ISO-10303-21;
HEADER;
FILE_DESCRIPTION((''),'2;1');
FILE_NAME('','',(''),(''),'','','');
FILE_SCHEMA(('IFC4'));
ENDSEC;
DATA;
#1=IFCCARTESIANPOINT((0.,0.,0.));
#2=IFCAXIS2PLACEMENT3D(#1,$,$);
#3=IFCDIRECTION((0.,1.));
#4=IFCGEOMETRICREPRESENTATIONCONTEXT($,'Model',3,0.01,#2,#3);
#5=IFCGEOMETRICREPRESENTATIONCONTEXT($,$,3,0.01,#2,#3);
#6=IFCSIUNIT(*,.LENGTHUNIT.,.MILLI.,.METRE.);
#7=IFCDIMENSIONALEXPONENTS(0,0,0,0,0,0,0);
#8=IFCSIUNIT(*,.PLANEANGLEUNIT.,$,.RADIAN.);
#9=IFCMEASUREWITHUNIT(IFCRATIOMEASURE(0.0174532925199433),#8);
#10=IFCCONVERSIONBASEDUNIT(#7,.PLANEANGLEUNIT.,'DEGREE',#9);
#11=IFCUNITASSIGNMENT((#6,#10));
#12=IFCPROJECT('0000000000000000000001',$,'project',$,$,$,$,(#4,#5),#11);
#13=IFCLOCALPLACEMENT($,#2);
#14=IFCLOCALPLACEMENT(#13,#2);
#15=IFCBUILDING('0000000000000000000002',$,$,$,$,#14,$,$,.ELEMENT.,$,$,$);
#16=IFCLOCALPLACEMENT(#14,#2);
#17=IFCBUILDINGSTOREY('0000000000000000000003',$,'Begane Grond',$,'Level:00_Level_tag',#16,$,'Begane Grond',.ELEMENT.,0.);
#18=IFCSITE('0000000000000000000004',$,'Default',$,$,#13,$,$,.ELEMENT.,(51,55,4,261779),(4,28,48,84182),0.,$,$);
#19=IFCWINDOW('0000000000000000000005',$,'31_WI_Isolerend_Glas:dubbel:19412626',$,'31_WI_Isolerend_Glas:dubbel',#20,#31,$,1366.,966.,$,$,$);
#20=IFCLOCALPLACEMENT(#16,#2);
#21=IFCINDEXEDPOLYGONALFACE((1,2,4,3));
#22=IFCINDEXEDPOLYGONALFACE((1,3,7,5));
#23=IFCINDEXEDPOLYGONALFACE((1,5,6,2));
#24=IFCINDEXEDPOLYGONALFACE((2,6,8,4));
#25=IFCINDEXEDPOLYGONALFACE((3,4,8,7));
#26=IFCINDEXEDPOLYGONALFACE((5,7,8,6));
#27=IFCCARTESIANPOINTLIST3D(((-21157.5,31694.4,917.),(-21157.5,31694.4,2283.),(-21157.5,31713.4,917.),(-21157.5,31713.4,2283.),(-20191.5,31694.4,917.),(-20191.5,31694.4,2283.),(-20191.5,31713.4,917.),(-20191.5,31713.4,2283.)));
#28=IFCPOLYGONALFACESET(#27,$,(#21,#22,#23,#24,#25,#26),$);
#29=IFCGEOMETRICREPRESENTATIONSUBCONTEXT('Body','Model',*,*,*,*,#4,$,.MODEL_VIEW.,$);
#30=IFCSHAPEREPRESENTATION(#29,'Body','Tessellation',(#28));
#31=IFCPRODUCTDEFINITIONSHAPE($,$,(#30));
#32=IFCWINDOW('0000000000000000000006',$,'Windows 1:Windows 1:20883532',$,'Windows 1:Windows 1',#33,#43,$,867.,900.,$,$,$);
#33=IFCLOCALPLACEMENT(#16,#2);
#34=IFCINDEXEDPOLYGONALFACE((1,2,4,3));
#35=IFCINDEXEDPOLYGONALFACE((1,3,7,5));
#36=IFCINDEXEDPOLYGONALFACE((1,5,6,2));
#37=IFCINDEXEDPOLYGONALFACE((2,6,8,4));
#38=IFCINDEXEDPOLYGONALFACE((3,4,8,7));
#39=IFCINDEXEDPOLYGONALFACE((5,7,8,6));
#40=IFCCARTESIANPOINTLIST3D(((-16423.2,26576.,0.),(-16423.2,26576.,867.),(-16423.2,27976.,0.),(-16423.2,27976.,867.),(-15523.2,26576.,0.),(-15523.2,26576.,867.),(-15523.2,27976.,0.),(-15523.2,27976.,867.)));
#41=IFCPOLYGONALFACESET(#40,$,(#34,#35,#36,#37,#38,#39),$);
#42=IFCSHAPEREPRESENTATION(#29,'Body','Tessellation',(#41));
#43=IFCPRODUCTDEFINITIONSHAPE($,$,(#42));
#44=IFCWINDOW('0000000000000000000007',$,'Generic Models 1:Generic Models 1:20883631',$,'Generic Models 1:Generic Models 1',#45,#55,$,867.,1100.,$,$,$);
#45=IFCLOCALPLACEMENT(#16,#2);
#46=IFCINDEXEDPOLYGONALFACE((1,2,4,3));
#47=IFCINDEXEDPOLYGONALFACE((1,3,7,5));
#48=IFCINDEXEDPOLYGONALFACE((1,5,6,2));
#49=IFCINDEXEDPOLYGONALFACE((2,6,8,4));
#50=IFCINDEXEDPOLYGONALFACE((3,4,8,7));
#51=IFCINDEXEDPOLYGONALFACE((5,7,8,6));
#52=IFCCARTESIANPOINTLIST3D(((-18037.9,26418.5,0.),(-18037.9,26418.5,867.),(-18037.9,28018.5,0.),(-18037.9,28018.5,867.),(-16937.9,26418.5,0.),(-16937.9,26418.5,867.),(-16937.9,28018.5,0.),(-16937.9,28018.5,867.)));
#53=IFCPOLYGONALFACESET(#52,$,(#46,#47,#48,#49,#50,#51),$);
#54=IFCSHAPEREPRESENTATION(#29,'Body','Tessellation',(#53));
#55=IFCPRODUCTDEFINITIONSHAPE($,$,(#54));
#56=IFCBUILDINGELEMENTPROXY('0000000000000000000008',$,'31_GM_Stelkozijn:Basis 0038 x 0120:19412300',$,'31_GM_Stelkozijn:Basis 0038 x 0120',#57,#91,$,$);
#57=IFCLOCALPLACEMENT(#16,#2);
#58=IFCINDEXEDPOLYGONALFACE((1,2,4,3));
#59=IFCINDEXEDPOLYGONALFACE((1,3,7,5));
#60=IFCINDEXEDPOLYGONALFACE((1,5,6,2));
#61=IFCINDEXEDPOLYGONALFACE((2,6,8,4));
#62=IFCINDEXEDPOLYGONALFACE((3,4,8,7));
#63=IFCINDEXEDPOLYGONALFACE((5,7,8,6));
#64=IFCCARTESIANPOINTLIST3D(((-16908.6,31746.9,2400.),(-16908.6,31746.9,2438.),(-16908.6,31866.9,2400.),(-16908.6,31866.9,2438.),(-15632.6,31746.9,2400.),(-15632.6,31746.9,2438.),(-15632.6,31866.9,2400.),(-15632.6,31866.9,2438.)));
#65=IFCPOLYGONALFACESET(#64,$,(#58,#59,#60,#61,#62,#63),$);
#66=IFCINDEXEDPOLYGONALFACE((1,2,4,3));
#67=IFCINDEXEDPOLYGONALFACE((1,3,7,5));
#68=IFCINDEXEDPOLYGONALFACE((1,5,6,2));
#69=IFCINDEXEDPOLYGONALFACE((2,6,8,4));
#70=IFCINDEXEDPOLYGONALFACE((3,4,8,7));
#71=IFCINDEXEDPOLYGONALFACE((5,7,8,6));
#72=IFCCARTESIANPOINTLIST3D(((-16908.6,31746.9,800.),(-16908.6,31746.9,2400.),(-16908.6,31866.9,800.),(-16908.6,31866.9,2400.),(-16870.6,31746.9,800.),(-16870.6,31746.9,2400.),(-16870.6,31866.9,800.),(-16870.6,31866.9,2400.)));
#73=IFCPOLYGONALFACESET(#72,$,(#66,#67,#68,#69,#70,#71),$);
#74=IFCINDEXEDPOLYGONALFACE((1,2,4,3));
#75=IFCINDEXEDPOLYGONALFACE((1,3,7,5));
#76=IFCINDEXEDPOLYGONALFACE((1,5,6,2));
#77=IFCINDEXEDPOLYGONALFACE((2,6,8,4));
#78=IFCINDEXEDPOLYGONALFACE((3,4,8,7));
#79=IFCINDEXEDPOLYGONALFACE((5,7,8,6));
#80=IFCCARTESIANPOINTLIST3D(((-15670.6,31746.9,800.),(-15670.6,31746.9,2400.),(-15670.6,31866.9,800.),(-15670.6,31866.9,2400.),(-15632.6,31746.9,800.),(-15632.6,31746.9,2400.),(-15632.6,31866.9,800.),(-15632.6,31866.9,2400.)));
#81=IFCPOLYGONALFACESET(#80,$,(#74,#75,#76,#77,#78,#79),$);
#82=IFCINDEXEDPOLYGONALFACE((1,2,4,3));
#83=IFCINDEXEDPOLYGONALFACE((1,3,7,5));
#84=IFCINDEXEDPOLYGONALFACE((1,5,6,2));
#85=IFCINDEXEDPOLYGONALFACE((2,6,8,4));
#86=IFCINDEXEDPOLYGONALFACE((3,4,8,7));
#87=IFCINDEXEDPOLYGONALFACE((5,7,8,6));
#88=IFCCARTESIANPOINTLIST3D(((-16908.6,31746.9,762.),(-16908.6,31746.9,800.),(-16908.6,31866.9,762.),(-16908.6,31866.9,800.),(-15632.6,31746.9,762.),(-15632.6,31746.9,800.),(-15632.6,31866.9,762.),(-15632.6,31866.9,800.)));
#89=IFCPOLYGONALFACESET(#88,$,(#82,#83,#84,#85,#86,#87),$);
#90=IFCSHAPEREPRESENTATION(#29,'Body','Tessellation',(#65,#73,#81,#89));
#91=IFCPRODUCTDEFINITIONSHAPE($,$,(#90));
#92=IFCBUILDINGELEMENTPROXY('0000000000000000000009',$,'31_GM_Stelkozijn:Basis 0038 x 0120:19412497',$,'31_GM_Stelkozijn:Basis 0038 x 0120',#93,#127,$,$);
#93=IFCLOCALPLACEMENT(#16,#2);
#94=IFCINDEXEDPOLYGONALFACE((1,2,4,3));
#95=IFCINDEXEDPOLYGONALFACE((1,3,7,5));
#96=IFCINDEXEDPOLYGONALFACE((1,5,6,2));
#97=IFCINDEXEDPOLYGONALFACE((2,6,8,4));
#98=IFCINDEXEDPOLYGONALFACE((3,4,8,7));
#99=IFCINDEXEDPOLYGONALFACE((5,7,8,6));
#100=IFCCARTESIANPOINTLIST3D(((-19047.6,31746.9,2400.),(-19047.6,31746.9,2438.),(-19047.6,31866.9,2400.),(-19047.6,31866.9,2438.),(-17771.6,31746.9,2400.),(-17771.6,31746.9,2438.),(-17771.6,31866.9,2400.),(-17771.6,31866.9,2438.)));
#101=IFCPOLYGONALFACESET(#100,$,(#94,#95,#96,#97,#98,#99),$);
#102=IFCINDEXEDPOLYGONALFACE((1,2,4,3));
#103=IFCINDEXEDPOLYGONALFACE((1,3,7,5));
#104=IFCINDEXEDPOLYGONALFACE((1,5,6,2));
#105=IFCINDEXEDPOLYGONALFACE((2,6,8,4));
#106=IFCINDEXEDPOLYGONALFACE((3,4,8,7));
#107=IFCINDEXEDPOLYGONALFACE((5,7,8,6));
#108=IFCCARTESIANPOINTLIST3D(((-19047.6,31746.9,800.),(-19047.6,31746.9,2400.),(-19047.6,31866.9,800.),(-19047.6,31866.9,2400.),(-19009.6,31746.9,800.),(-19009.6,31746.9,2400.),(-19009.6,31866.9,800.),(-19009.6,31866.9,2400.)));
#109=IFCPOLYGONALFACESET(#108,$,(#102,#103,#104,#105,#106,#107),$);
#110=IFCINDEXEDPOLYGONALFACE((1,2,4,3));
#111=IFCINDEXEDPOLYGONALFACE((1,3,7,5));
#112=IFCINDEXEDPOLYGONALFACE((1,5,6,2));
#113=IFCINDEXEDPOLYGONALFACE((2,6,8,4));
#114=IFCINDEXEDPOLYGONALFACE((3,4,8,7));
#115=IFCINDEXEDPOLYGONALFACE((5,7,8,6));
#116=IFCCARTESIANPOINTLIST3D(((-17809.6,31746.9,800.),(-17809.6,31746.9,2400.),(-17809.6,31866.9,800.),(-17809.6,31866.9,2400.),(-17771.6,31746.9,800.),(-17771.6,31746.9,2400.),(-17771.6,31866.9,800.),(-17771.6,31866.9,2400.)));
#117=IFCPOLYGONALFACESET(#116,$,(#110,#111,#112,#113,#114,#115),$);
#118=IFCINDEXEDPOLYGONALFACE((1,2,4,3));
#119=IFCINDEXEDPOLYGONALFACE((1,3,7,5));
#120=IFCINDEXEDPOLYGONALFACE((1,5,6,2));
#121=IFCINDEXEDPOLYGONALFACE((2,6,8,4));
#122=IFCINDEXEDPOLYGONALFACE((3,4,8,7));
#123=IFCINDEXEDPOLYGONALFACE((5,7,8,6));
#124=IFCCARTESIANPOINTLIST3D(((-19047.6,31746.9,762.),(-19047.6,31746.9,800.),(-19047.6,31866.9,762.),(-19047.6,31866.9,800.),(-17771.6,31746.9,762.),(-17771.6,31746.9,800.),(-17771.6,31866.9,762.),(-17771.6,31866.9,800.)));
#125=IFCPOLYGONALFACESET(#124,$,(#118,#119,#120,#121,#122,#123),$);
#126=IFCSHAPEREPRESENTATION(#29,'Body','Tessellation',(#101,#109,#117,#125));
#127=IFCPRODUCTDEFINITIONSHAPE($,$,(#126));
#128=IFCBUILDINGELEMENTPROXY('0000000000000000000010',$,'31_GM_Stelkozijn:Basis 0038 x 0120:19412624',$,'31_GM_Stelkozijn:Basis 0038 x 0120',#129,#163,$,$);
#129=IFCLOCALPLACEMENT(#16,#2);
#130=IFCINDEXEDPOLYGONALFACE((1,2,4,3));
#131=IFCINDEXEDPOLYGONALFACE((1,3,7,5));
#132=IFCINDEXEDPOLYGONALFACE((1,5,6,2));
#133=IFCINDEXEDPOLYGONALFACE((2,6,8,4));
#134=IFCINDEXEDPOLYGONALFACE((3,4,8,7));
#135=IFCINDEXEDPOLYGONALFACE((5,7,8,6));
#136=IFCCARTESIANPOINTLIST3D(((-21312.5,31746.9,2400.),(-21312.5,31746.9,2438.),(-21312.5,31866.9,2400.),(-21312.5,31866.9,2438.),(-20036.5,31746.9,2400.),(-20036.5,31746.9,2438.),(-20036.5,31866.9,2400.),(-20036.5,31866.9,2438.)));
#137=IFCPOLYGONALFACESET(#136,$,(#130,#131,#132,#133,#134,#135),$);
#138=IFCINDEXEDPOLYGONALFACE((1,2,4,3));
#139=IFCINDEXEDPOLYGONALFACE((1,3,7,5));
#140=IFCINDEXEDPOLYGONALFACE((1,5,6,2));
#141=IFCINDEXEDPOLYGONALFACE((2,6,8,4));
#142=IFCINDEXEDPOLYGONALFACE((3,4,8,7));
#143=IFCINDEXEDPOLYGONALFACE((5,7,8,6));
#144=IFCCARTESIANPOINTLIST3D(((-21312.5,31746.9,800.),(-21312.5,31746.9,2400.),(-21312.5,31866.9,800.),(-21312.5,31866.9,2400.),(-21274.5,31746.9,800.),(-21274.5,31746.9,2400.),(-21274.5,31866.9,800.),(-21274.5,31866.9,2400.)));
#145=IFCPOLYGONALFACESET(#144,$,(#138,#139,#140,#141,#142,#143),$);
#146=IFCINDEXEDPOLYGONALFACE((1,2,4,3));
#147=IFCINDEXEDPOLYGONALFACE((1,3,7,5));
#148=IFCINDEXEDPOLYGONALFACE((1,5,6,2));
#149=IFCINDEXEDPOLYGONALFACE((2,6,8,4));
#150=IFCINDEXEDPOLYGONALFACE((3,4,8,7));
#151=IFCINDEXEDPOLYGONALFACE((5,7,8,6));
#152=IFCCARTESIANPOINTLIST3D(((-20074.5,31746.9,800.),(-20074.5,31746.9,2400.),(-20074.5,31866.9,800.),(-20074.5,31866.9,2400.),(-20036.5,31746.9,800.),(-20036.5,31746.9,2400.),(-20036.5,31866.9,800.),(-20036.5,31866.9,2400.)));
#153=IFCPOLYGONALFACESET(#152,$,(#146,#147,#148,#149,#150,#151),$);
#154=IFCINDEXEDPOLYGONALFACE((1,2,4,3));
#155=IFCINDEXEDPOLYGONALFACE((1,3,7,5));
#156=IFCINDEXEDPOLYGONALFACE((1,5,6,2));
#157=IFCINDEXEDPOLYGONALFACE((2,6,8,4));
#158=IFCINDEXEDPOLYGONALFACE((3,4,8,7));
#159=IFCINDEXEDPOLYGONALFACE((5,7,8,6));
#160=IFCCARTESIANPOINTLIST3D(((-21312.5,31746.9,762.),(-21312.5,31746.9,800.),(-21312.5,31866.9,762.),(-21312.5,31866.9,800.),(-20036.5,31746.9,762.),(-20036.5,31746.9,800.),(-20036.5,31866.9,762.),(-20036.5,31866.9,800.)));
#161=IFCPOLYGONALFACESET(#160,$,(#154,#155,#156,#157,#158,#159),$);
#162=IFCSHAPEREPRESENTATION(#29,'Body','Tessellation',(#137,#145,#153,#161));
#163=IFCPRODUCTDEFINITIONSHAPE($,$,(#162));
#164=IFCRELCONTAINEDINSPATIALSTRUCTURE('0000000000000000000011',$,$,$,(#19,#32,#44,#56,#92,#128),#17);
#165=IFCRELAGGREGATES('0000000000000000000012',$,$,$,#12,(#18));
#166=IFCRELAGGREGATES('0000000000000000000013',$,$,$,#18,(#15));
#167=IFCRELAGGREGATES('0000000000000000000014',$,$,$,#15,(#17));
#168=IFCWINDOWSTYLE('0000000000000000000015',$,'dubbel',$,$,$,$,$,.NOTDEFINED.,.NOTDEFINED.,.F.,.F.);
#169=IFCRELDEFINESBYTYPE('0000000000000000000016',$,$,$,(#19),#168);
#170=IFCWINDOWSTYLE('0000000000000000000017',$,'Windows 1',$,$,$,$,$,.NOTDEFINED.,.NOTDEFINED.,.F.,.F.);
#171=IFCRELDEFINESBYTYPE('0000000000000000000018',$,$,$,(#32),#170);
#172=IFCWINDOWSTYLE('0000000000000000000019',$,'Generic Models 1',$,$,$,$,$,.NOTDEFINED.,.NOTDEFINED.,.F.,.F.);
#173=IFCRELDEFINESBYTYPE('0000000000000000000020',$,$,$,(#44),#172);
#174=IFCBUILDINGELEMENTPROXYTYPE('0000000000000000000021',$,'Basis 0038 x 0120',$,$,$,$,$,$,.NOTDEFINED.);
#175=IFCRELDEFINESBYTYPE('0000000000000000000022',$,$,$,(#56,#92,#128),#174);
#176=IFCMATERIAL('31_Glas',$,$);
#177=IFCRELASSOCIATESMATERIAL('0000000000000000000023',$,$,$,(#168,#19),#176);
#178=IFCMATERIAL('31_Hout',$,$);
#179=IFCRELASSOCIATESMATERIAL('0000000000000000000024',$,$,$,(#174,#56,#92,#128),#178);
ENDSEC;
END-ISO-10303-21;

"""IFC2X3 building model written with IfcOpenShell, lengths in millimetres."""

from ifc_helpers import new_model, entity, si_unit, converted_unit, direction, frame, frame_2d, origin, origin_2d_with_axis, place, context, subcontext, project, spatial, rectangle, extrude, source, transform, mapped, material, type_object, type_shapes, element, save


model = new_model("IFC2X3")

# Units and contexts
model_context = context("Model", 3, precision=0.01, world=origin(), true_north=direction((0.0, 1.0)))
context_of_model = context(None, 3, precision=0.01, world=origin(), true_north=direction((0.0, 1.0)))
body_context = subcontext(model_context, "Body", "Model", "MODEL_VIEW")
ifc_project = project(units=[si_unit("LENGTHUNIT", "METRE", prefix="MILLI"), converted_unit("PLANEANGLEUNIT", "DEGREE", entity("IfcRatioMeasure", 0.0174532925199433), si_unit("PLANEANGLEUNIT", "RADIAN"), dimensions=[0, 0, 0, 0, 0, 0, 0])], contexts=[model_context, context_of_model])

# Site, building, storey
site_placement = place(None, origin())
site = spatial("IfcSite", under=ifc_project, at=site_placement, Name="Default", CompositionType="ELEMENT", RefLatitude=(51, 55, 4, 261779), RefLongitude=(4, 28, 48, 84182), RefElevation=0.0)
building_placement = place(site_placement, origin())
building = spatial("IfcBuilding", under=site, at=building_placement, CompositionType="ELEMENT")
storey_placement = place(building_placement, origin())
storey = spatial("IfcBuildingStorey", under=building, at=storey_placement, Name="Begane Grond", ObjectType="Level:00_Level_tag", LongName="Begane Grond", CompositionType="ELEMENT", Elevation=0.0)

# Windows
ifc_material_1 = material(Name="31_Glas")
window_style_1 = type_object("IfcWindowStyle", Name="dubbel", ConstructionType="NOTDEFINED", OperationType="NOTDEFINED", ParameterTakesPrecedence=False, Sizeable=False, material=ifc_material_1)
shared_shape_1 = source(origin(), body_context, "Body", "SweptSolid", [
    extrude(rectangle(XDim=19.0, YDim=966.0, at=frame_2d((0.0, 0.0), x_axis=(1.0, 0.0))), frame((0.0, -28.5, 0.0), z_axis=(0.0, 0.0, 1.0), x_axis=(0.0, 1.0, 0.0)), (0.0, 0.0, 1.0), 1366.0),
])
type_shapes(window_style_1, [shared_shape_1])
window_1_placement = place(storey_placement, frame((-20674.5, 31675.4, 917.0), z_axis=(0.0, 0.0, 1.0), x_axis=(-1.0, 0.0, 0.0)))
element("IfcWindow", 1, at=window_1_placement, inside=storey, type_object=window_style_1, material=ifc_material_1, Name="31_WI_Isolerend_Glas:dubbel:19412626", ObjectType="31_WI_Isolerend_Glas:dubbel", OverallHeight=1366.0, OverallWidth=966.0, context=body_context, shape_type="MappedRepresentation", body=[
    mapped(shared_shape_1, transform((0.0, 0.0, 0.0), scale=1.0)),
])
window_style_2 = type_object("IfcWindowStyle", Name="Windows 1", ConstructionType="NOTDEFINED", OperationType="NOTDEFINED", ParameterTakesPrecedence=False, Sizeable=False)
shared_shape_2 = source(origin(), body_context, "Body", "SweptSolid", [
    extrude(rectangle(XDim=900.0, YDim=1400.0, at=frame_2d((0.0, 0.0), x_axis=(1.0, 0.0))), frame((-15973.4, 27160.4, 0.0), z_axis=(0.0, 0.0, 1.0), x_axis=(-1.0, 0.0, 0.0)), (0.0, 0.0, 1.0), 867.0),
])
type_shapes(window_style_2, [shared_shape_2])
window_2_placement = place(storey_placement, frame((0.2, 115.6, 0.0)))
element("IfcWindow", 2, at=window_2_placement, inside=storey, type_object=window_style_2, Name="Windows 1:Windows 1:20883532", ObjectType="Windows 1:Windows 1", OverallHeight=867.0, OverallWidth=900.0, context=body_context, shape_type="MappedRepresentation", body=[
    mapped(shared_shape_2, transform((0.0, 0.0, 0.0), scale=1.0)),
])
window_style_3 = type_object("IfcWindowStyle", Name="Generic Models 1", ConstructionType="NOTDEFINED", OperationType="NOTDEFINED", ParameterTakesPrecedence=False, Sizeable=False)
shared_shape_3 = source(origin(), body_context, "Body", "SweptSolid", [
    extrude(rectangle(XDim=1100.0, YDim=1600.0, at=origin_2d_with_axis()), frame((-17487.9, 27218.5, 0.0)), (0.0, 0.0, 1.0), 867.0),
])
type_shapes(window_style_3, [shared_shape_3])
window_3_placement = place(storey_placement, origin())
element("IfcWindow", 3, at=window_3_placement, inside=storey, type_object=window_style_3, Name="Generic Models 1:Generic Models 1:20883631", ObjectType="Generic Models 1:Generic Models 1", OverallHeight=867.0, OverallWidth=1100.0, context=body_context, shape_type="MappedRepresentation", body=[
    mapped(shared_shape_3, transform((0.0, 0.0, 0.0), scale=1.0)),
])

# Building element proxies
ifc_material_2 = material(Name="31_Hout")
building_element_proxy_type_1 = type_object("IfcBuildingElementProxyType", Name="Basis 0038 x 0120", PredefinedType="NOTDEFINED", material=ifc_material_2)
shared_shape_4 = source(origin(), body_context, "Body", "SweptSolid", [
    extrude(rectangle(XDim=1276.0, YDim=120.0, at=origin_2d_with_axis()), frame((0.0, 0.5, 1638.0), z_axis=(0.0, 0.0, 1.0), x_axis=(-1.0, 0.0, 0.0)), (0.0, 0.0, 1.0), 38.0),
    extrude(rectangle(XDim=38.0, YDim=120.0, at=frame_2d((0.0, 0.0), x_axis=(1.0, 0.0))), frame((619.0, 0.5, 38.0), z_axis=(0.0, 0.0, 1.0), x_axis=(-1.0, 0.0, 0.0)), (0.0, 0.0, 1.0), 1600.0),
    extrude(rectangle(XDim=38.0, YDim=120.0, at=frame_2d((0.0, 0.0), x_axis=(1.0, 0.0))), frame((-619.0, 0.5, 38.0), z_axis=(0.0, 0.0, 1.0), x_axis=(-1.0, 0.0, 0.0)), (0.0, 0.0, 1.0), 1600.0),
    extrude(rectangle(XDim=1276.0, YDim=120.0, at=origin_2d_with_axis()), frame((0.0, 0.5, 0.0), z_axis=(0.0, 0.0, 1.0), x_axis=(-1.0, 0.0, 0.0)), (0.0, 0.0, 1.0), 38.0),
])
type_shapes(building_element_proxy_type_1, [shared_shape_4])
for number, where, z_axis, x_axis, name in (
    (4, (-16270.6, 31807.4, 762.0), (0.0, 0.0, 1.0), (-1.0, 0.0, 0.0), "31_GM_Stelkozijn:Basis 0038 x 0120:19412300"),
    (5, (-18409.6, 31807.4, 762.0), (0.0, 0.0, 1.0), (-1.0, 0.0, 0.0), "31_GM_Stelkozijn:Basis 0038 x 0120:19412497"),
    (6, (-20674.5, 31807.4, 762.0), (0.0, 0.0, 1.0), (-1.0, 0.0, 0.0), "31_GM_Stelkozijn:Basis 0038 x 0120:19412624"),
):
    element("IfcBuildingElementProxy", number, at=place(storey_placement, frame(where, z_axis=z_axis, x_axis=x_axis)), inside=storey, type_object=building_element_proxy_type_1, material=ifc_material_2, Name=name, ObjectType="31_GM_Stelkozijn:Basis 0038 x 0120", context=body_context, shape_type="MappedRepresentation", body=[
        mapped(shared_shape_4, transform((0.0, 0.0, 0.0), scale=1.0)),
    ])

save(model, "model.ifc")
